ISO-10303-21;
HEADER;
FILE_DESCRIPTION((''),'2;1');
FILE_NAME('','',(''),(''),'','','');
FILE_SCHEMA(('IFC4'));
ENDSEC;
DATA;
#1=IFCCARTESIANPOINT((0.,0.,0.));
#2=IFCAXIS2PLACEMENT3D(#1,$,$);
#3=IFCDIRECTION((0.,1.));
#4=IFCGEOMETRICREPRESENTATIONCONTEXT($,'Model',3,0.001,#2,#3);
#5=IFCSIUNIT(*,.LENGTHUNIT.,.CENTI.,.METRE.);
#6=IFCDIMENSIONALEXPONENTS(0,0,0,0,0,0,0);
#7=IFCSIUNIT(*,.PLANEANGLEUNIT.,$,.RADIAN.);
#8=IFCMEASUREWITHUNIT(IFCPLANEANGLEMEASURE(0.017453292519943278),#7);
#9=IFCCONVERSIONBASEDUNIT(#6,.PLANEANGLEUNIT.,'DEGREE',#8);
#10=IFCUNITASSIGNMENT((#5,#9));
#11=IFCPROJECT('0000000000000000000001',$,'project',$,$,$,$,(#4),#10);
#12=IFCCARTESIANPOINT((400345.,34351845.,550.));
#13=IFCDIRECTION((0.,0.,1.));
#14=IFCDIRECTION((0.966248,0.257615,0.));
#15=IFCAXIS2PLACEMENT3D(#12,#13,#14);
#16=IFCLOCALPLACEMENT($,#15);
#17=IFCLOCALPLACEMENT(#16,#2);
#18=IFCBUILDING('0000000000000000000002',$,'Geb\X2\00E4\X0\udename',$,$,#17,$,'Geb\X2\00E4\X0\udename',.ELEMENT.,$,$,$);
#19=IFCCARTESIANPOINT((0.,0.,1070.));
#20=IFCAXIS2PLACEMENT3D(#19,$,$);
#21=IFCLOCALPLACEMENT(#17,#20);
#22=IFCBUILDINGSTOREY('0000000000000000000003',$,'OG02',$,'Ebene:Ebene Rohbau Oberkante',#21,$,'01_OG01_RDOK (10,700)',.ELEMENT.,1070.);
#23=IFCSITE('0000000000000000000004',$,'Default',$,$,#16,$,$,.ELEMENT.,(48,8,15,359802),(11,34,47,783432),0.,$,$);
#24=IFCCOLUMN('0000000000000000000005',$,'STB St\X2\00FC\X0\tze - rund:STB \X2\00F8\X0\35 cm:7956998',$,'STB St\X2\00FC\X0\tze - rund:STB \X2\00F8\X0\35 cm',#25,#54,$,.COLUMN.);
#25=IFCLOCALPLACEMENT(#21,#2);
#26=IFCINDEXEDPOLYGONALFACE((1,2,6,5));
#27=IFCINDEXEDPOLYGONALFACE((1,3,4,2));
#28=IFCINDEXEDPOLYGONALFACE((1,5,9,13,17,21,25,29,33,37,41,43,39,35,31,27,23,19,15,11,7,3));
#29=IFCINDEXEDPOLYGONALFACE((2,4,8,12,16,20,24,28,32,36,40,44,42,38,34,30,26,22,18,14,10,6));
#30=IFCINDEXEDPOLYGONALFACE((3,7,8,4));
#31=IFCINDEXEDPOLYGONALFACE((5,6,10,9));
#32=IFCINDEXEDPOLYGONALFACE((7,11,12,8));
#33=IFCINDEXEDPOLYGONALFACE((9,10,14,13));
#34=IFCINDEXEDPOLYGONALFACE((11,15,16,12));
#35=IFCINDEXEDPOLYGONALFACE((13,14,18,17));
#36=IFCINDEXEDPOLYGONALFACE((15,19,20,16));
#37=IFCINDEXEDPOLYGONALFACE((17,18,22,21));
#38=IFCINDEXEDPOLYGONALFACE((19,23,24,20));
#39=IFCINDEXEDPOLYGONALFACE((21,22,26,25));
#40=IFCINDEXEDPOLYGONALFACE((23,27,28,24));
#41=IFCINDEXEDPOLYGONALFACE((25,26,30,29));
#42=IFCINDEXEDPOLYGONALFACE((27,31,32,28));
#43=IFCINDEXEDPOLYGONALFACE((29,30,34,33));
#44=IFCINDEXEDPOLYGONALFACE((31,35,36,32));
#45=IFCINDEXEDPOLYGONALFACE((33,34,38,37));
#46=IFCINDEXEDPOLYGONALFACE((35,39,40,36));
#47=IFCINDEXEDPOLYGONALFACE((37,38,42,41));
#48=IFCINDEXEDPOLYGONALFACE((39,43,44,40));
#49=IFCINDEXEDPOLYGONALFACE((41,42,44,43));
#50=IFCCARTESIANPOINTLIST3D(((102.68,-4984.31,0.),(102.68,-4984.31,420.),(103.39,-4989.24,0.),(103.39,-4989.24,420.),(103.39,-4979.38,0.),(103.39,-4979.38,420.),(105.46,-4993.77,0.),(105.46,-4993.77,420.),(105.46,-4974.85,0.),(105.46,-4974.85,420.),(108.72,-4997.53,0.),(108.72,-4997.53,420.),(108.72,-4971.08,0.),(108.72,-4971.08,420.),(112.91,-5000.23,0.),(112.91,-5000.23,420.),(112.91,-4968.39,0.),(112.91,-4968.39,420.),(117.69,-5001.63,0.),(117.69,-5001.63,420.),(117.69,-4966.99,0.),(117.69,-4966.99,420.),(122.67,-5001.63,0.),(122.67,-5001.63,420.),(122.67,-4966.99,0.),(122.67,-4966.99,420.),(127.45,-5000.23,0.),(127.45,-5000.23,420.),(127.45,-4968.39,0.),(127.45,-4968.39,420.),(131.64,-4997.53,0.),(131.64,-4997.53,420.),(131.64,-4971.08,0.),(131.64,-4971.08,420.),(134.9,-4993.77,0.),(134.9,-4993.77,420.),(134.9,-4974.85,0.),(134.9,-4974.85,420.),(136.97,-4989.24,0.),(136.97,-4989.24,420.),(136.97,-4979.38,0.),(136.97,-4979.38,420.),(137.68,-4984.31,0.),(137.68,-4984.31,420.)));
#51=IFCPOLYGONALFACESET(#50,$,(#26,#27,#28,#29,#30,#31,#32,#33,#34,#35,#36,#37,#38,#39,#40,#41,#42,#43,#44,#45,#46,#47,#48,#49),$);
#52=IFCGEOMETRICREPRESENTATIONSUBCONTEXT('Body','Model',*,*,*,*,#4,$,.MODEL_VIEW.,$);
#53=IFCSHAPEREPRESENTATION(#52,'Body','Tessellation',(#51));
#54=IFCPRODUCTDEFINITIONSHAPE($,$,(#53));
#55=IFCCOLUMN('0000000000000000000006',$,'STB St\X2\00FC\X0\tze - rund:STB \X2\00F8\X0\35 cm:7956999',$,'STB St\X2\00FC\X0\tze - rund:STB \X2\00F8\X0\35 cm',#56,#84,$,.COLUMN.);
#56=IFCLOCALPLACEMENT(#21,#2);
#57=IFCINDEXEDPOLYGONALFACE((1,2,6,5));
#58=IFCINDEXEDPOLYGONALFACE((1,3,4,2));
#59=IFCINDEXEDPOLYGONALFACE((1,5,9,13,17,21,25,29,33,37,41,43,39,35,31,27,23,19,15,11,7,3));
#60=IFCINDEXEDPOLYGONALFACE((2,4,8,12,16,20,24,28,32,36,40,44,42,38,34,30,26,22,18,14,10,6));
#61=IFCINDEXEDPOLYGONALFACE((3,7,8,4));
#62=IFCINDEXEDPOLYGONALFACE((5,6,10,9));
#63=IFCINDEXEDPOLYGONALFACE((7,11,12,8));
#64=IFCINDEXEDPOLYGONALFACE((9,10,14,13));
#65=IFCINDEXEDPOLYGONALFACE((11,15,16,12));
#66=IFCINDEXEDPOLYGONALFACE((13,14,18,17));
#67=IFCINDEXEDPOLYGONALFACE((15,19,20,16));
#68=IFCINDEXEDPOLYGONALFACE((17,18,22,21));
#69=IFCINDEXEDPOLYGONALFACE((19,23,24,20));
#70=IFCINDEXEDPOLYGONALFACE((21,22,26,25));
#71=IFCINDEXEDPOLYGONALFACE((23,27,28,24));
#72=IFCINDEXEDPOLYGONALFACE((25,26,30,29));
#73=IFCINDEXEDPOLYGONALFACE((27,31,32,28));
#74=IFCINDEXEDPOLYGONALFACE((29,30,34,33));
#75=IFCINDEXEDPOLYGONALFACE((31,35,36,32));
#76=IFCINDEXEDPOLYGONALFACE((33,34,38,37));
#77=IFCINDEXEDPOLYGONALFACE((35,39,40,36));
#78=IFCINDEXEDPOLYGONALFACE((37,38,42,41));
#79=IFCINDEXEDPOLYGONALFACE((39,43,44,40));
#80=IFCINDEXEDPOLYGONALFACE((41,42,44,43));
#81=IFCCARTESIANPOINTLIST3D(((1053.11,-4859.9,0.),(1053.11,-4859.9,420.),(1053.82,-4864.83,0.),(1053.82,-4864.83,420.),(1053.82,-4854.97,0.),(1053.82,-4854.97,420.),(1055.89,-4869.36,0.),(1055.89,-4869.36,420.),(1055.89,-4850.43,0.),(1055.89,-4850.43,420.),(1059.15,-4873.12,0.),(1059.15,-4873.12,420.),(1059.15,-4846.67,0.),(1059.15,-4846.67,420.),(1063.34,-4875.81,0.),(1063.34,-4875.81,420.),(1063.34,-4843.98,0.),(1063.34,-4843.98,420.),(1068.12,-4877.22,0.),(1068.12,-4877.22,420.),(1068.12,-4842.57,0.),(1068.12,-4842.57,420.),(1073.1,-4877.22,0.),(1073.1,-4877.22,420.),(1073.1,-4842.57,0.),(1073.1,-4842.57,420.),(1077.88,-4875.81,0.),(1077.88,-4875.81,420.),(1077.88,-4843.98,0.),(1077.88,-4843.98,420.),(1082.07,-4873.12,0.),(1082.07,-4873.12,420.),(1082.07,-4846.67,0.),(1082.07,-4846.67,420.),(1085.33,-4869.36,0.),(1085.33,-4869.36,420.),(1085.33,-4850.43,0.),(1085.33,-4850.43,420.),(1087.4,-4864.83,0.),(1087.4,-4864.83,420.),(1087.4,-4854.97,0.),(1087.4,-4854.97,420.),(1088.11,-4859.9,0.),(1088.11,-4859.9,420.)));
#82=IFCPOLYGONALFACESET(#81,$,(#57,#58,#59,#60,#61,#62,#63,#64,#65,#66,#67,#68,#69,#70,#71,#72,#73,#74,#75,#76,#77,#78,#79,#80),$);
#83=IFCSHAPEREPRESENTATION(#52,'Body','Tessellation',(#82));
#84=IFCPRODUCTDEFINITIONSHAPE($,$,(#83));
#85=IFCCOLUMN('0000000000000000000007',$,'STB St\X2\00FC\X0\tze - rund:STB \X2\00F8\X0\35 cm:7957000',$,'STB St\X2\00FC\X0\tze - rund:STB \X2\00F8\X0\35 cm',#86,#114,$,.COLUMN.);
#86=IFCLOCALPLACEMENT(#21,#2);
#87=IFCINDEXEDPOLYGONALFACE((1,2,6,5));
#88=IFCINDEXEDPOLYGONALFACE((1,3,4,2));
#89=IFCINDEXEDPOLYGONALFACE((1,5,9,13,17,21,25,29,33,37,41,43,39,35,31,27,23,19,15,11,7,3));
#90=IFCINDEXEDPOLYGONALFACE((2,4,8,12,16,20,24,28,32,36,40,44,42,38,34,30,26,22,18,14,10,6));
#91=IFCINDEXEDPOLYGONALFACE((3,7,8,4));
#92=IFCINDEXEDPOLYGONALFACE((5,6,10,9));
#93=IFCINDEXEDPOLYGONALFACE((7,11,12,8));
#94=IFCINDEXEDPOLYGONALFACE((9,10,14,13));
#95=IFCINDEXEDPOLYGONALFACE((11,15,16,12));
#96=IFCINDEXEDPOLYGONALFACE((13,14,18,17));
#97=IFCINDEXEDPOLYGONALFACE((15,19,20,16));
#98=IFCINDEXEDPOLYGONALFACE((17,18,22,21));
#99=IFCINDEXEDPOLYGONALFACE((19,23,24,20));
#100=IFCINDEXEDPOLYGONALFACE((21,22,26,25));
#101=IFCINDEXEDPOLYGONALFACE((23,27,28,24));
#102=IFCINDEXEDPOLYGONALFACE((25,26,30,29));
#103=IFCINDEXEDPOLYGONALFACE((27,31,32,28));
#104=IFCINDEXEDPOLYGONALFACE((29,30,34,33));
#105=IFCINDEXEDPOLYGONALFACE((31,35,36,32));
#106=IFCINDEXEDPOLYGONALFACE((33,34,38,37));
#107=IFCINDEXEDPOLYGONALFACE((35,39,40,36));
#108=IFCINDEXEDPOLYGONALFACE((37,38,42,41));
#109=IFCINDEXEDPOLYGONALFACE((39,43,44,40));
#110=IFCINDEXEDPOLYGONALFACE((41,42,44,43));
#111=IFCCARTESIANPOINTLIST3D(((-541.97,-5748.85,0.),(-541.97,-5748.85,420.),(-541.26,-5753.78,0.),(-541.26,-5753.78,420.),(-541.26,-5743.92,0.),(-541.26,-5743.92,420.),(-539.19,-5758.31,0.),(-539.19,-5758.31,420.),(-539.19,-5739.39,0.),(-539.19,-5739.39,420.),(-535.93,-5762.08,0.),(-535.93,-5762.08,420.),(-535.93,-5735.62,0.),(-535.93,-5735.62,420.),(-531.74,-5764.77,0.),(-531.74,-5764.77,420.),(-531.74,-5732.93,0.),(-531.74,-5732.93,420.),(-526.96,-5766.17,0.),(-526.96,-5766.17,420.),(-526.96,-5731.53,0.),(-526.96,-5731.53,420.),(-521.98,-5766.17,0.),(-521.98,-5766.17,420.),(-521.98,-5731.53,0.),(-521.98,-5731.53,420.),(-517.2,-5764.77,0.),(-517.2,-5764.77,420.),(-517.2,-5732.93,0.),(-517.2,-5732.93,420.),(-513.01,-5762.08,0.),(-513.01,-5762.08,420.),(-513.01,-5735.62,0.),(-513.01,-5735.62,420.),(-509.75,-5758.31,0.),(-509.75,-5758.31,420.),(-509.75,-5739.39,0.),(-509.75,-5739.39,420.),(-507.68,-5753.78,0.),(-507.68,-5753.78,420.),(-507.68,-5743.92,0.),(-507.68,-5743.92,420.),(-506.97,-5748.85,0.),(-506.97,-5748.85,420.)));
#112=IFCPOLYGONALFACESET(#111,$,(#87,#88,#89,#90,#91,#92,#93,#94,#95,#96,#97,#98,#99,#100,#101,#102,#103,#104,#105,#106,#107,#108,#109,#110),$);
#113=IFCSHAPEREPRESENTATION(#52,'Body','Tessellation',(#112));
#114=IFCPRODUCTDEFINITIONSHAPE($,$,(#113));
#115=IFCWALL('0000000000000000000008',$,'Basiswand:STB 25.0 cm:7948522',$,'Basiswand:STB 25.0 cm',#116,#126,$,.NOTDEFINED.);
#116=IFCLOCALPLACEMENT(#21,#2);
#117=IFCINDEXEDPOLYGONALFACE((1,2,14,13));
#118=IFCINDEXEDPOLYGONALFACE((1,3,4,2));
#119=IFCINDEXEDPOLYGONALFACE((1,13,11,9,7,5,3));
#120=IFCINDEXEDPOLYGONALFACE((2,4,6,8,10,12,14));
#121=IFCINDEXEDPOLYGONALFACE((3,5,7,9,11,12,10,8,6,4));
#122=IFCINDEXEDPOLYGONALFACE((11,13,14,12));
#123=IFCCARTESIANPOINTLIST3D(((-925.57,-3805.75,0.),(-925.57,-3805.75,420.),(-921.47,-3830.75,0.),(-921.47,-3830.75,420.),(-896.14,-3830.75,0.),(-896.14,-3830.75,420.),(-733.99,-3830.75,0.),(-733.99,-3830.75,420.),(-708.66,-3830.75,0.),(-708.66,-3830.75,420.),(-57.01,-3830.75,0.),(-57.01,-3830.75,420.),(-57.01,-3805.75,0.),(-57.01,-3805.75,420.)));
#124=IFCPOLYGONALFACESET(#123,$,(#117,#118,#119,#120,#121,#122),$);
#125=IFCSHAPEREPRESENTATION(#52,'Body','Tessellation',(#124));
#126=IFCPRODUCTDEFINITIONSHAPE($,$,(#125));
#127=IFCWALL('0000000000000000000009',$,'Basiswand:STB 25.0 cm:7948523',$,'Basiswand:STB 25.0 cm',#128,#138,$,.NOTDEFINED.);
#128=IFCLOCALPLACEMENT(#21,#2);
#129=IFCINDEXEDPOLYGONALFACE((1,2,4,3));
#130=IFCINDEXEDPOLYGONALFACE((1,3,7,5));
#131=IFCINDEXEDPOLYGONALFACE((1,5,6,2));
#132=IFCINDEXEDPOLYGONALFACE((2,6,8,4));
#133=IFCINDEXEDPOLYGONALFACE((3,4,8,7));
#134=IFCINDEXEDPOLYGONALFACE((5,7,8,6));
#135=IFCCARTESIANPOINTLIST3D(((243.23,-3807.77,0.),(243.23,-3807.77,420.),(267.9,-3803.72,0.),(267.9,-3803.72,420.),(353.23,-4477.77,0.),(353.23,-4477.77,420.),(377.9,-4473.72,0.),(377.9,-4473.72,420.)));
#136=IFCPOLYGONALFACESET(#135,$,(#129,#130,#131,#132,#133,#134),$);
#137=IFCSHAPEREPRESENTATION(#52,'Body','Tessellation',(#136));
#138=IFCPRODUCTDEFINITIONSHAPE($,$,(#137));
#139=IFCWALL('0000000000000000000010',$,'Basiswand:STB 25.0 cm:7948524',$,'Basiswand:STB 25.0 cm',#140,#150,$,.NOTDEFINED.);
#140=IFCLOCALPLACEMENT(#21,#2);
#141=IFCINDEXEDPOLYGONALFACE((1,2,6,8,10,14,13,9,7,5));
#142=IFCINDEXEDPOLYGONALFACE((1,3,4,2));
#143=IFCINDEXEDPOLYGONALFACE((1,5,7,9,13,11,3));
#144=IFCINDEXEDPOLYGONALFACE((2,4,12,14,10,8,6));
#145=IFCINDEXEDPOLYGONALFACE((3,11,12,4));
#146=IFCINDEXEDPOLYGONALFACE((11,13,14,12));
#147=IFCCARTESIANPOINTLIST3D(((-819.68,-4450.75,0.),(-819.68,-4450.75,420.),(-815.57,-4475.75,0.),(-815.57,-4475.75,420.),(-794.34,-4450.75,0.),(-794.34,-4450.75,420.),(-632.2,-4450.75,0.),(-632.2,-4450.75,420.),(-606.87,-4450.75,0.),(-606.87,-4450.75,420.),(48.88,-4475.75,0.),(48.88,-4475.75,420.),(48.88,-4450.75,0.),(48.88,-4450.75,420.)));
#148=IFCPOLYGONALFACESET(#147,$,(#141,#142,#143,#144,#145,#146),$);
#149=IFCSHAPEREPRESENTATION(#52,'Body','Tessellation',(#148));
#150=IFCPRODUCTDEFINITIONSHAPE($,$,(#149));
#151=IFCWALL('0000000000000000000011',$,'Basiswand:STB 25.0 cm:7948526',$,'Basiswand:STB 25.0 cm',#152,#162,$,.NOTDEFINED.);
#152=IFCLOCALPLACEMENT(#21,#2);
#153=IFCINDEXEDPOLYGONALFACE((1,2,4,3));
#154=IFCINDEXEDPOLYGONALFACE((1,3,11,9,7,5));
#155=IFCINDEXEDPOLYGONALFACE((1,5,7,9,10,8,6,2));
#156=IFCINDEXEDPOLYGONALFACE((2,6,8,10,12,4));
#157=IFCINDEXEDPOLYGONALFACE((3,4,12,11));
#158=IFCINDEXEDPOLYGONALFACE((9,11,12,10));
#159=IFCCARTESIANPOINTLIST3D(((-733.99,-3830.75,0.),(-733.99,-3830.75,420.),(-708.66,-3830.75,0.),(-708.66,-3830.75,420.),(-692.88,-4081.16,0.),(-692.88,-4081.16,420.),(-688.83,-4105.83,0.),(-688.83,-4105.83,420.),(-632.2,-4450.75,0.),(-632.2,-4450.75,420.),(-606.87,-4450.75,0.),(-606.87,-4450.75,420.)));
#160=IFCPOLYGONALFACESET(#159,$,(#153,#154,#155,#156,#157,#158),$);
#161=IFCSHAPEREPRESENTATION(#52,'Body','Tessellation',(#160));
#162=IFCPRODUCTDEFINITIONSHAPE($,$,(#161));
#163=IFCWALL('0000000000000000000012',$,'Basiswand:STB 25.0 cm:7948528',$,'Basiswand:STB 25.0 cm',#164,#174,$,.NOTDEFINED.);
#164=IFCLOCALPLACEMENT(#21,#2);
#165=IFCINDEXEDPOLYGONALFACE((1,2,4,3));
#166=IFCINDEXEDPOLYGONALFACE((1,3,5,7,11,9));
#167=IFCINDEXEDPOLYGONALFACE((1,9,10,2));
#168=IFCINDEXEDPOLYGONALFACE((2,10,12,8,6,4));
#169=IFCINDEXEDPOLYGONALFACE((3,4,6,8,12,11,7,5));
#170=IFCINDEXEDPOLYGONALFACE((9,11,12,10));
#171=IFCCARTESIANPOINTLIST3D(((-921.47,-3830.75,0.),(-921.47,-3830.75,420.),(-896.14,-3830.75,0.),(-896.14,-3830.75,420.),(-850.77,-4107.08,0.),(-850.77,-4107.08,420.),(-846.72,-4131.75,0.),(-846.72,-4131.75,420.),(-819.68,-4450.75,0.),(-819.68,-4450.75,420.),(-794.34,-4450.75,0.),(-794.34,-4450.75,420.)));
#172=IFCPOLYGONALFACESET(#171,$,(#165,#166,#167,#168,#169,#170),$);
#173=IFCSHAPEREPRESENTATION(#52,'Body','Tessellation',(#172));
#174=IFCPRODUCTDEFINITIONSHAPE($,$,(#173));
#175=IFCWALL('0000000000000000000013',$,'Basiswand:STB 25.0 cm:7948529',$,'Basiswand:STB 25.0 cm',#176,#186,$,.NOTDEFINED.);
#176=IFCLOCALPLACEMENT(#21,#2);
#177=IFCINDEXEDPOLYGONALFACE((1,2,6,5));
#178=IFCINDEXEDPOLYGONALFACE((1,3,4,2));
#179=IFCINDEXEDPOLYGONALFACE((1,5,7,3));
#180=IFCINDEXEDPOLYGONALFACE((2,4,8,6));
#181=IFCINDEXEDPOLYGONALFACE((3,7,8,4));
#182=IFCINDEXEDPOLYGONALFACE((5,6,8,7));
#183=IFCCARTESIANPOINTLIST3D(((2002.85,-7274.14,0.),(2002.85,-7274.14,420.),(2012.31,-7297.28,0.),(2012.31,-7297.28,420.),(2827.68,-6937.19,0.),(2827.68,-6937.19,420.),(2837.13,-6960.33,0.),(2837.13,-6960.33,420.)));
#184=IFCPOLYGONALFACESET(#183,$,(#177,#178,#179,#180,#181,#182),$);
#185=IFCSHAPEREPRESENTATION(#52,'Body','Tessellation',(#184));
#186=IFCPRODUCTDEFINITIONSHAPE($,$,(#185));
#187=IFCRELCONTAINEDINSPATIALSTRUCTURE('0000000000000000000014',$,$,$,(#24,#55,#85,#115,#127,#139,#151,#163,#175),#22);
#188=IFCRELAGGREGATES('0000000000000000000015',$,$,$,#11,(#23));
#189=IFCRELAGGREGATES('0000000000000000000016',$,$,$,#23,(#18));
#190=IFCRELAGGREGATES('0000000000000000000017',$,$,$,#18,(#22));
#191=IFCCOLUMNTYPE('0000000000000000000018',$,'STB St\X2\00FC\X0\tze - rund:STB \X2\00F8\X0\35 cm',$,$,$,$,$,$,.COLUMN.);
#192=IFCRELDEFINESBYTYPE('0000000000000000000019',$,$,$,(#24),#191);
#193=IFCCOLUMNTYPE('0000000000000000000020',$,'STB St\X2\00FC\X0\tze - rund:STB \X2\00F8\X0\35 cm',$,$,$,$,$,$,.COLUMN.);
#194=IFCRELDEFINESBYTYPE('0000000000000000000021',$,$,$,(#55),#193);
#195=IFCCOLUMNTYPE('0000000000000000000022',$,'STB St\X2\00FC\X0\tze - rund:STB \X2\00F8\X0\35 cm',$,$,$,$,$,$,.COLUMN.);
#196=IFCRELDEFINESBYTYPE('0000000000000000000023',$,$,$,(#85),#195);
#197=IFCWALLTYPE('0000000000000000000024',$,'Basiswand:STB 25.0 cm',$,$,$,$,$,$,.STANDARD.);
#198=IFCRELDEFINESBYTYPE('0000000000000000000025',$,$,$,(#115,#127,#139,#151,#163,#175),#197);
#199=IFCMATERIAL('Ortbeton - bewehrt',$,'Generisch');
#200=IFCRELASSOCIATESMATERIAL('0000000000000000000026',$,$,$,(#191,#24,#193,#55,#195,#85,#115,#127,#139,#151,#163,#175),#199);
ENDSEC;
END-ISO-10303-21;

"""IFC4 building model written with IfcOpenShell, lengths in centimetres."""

from ifc_helpers import new_model, entity, si_unit, converted_unit, direction, frame, origin, place, context, subcontext, project, spatial, arc, indexed_curve, outline, extrude, source, transform, mapped, material, type_object, type_shapes, element, save


model = new_model("IFC4")

# Units and contexts
model_context = context("Model", 3, precision=0.001, world=origin(), true_north=direction((0.0, 1.0)))
body_context = subcontext(model_context, "Body", "Model", "MODEL_VIEW")
ifc_project = project(units=[si_unit("LENGTHUNIT", "METRE", prefix="CENTI"), converted_unit("PLANEANGLEUNIT", "DEGREE", entity("IfcPlaneAngleMeasure", 0.017453292519943278), si_unit("PLANEANGLEUNIT", "RADIAN"), dimensions=[0, 0, 0, 0, 0, 0, 0])], contexts=[model_context])

# Site, building, storey
site_placement = place(None, frame((400345.0, 34351845.0, 550.0), z_axis=(0.0, 0.0, 1.0), x_axis=(0.966248, 0.257615, 0.0)))
site = spatial("IfcSite", under=ifc_project, at=site_placement, Name="Default", CompositionType="ELEMENT", RefLatitude=(48, 8, 15, 359802), RefLongitude=(11, 34, 47, 783432), RefElevation=0.0)
building_placement = place(site_placement, origin())
building = spatial("IfcBuilding", under=site, at=building_placement, Name="Gebäudename", LongName="Gebäudename", CompositionType="ELEMENT")
storey_placement = place(building_placement, frame((0.0, 0.0, 1070.0)))
storey = spatial("IfcBuildingStorey", under=building, at=storey_placement, Name="OG02", ObjectType="Ebene:Ebene Rohbau Oberkante", LongName="01_OG01_RDOK (10,700)", CompositionType="ELEMENT", Elevation=1070.0)

# Columns
ifc_material = material(Name="Ortbeton - bewehrt", Category="Generisch")
column_type_1 = type_object("IfcColumnType", Name="STB Stütze - rund:STB ø35 cm", PredefinedType="COLUMN", material=ifc_material)
shared_shape_1 = source(origin(), body_context, "Body", "SweptSolid", [
    extrude(outline(indexed_curve([(-17.5, 0.0), (0.0, -17.5), (17.5, 0.0), (0.0, 17.5)], segments=[arc(1, 2, 3), arc(3, 4, 1)], self_intersect=False)), frame((120.18, -4984.31, 1070.0)), (0.0, 0.0, 1.0), 420.0),
])
type_shapes(column_type_1, [shared_shape_1])
column_1_placement = place(storey_placement, frame((0.0, 0.0, -1070.0)))
element("IfcColumn", 1, at=column_1_placement, inside=storey, type_object=column_type_1, material=ifc_material, Name="STB Stütze - rund:STB ø35 cm:7956998", ObjectType="STB Stütze - rund:STB ø35 cm", PredefinedType="COLUMN", context=body_context, shape_type="MappedRepresentation", body=[
    mapped(shared_shape_1, transform((0.0, 0.0, 0.0), scale=1.0)),
])
column_type_2 = type_object("IfcColumnType", Name="STB Stütze - rund:STB ø35 cm", PredefinedType="COLUMN", material=ifc_material)
shared_shape_2 = source(origin(), body_context, "Body", "SweptSolid", [
    extrude(outline(indexed_curve([(-17.5, 0.0), (0.0, -17.5), (17.5, 0.0), (0.0, 17.5)], segments=[arc(1, 2, 3), arc(3, 4, 1)], self_intersect=False)), frame((1070.61, -4859.9, 1070.0)), (0.0, 0.0, 1.0), 420.0),
])
type_shapes(column_type_2, [shared_shape_2])
column_2_placement = place(storey_placement, frame((0.0, 0.0, -1070.0)))
element("IfcColumn", 2, at=column_2_placement, inside=storey, type_object=column_type_2, material=ifc_material, Name="STB Stütze - rund:STB ø35 cm:7956999", ObjectType="STB Stütze - rund:STB ø35 cm", PredefinedType="COLUMN", context=body_context, shape_type="MappedRepresentation", body=[
    mapped(shared_shape_2, transform((0.0, 0.0, 0.0), scale=1.0)),
])
column_type_3 = type_object("IfcColumnType", Name="STB Stütze - rund:STB ø35 cm", PredefinedType="COLUMN", material=ifc_material)
shared_shape_3 = source(origin(), body_context, "Body", "SweptSolid", [
    extrude(outline(indexed_curve([(-17.5, 0.0), (0.0, -17.5), (17.5, 0.0), (0.0, 17.5)], segments=[arc(1, 2, 3), arc(3, 4, 1)], self_intersect=False)), frame((-524.47, -5748.85, 1070.0)), (0.0, 0.0, 1.0), 420.0),
])
type_shapes(column_type_3, [shared_shape_3])
column_3_placement = place(storey_placement, frame((0.0, 0.0, -1070.0)))
element("IfcColumn", 3, at=column_3_placement, inside=storey, type_object=column_type_3, material=ifc_material, Name="STB Stütze - rund:STB ø35 cm:7957000", ObjectType="STB Stütze - rund:STB ø35 cm", PredefinedType="COLUMN", context=body_context, shape_type="MappedRepresentation", body=[
    mapped(shared_shape_3, transform((0.0, 0.0, 0.0), scale=1.0)),
])

# Walls
wall_type = type_object("IfcWallType", Name="Basiswand:STB 25.0 cm", PredefinedType="STANDARD")
wall_1_placement = place(storey_placement, frame((-925.57, -3818.25, 0.0)))
element("IfcWall", 4, at=wall_1_placement, inside=storey, type_object=wall_type, material=ifc_material, Name="Basiswand:STB 25.0 cm:7948522", ObjectType="Basiswand:STB 25.0 cm", PredefinedType="NOTDEFINED", context=body_context, shape_type="SweptSolid", body=[
    extrude(outline(indexed_curve([(868.56, -12.5), (868.56, 12.5), (0.0, 12.5), (4.1, -12.5), (29.44, -12.5), (191.58, -12.5), (216.92, -12.5), (868.56, -12.5)], self_intersect=False)), origin(), (0.0, 0.0, 1.0), 420.0),
])
wall_2_placement = place(storey_placement, frame((255.57, -3805.75, 0.0), z_axis=(0.0, 0.0, 1.0), x_axis=(0.162011, -0.986789, 0.0)))
element("IfcWall", 5, at=wall_2_placement, inside=storey, type_object=wall_type, material=ifc_material, Name="Basiswand:STB 25.0 cm:7948523", ObjectType="Basiswand:STB 25.0 cm", PredefinedType="NOTDEFINED", context=body_context, shape_type="SweptSolid", body=[
    extrude(outline(indexed_curve([(678.97, 12.5), (0.0, 12.5), (0.0, -12.5), (678.97, -12.5), (678.97, 12.5)], self_intersect=False)), origin(), (0.0, 0.0, 1.0), 420.0),
])
wall_3_placement = place(storey_placement, frame((48.88, -4463.25, 0.0), z_axis=(0.0, 0.0, 1.0), x_axis=(-1.0, 0.0, 0.0)))
element("IfcWall", 6, at=wall_3_placement, inside=storey, type_object=wall_type, material=ifc_material, Name="Basiswand:STB 25.0 cm:7948524", ObjectType="Basiswand:STB 25.0 cm", PredefinedType="NOTDEFINED", context=body_context, shape_type="SweptSolid", body=[
    extrude(outline(indexed_curve([(868.56, -12.5), (864.46, 12.5), (0.0, 12.5), (0.0, -12.5), (655.75, -12.5), (681.08, -12.5), (843.23, -12.5), (868.56, -12.5)], self_intersect=False)), origin(), (0.0, 0.0, 1.0), 420.0),
])
wall_4_placement = place(storey_placement, frame((-721.66, -3828.72, 0.0), z_axis=(0.0, 0.0, 1.0), x_axis=(0.162011, -0.986789, 0.0)))
element("IfcWall", 7, at=wall_4_placement, inside=storey, type_object=wall_type, material=ifc_material, Name="Basiswand:STB 25.0 cm:7948526", ObjectType="Basiswand:STB 25.0 cm", PredefinedType="NOTDEFINED", context=body_context, shape_type="SweptSolid", body=[
    extrude(outline(indexed_curve([(628.3, -12.5), (632.41, 12.5), (4.1, 12.5), (0.0, -12.5), (253.77, -12.5), (278.77, -12.5), (628.3, -12.5)], self_intersect=False)), origin(), (0.0, 0.0, 1.0), 420.0),
])
wall_5_placement = place(storey_placement, frame((-806.68, -4452.77, 0.0), z_axis=(0.0, 0.0, 1.0), x_axis=(-0.162011, 0.986789, 0.0)))
element("IfcWall", 8, at=wall_5_placement, inside=storey, type_object=wall_type, material=ifc_material, Name="Basiswand:STB 25.0 cm:7948528", ObjectType="Basiswand:STB 25.0 cm", PredefinedType="NOTDEFINED", context=body_context, shape_type="SweptSolid", body=[
    extrude(outline(indexed_curve([(628.3, -12.5), (632.41, 12.5), (4.1, 12.5), (0.0, -12.5), (323.26, -12.5), (348.26, -12.5), (628.3, -12.5)], self_intersect=False)), origin(), (0.0, 0.0, 1.0), 420.0),
])
wall_6_placement = place(storey_placement, frame((2007.58, -7285.71, 0.0), z_axis=(0.0, 0.0, 1.0), x_axis=(0.925734, 0.378175, 0.0)))
element("IfcWall", 9, at=wall_6_placement, inside=storey, type_object=wall_type, material=ifc_material, Name="Basiswand:STB 25.0 cm:7948529", ObjectType="Basiswand:STB 25.0 cm", PredefinedType="NOTDEFINED", context=body_context, shape_type="SweptSolid", body=[
    extrude(outline(indexed_curve([(891.0, 12.5), (0.0, 12.5), (0.0, -12.5), (891.0, -12.5), (891.0, 12.5)], self_intersect=False)), origin(), (0.0, 0.0, 1.0), 420.0),
])

save(model, "model.ifc")
